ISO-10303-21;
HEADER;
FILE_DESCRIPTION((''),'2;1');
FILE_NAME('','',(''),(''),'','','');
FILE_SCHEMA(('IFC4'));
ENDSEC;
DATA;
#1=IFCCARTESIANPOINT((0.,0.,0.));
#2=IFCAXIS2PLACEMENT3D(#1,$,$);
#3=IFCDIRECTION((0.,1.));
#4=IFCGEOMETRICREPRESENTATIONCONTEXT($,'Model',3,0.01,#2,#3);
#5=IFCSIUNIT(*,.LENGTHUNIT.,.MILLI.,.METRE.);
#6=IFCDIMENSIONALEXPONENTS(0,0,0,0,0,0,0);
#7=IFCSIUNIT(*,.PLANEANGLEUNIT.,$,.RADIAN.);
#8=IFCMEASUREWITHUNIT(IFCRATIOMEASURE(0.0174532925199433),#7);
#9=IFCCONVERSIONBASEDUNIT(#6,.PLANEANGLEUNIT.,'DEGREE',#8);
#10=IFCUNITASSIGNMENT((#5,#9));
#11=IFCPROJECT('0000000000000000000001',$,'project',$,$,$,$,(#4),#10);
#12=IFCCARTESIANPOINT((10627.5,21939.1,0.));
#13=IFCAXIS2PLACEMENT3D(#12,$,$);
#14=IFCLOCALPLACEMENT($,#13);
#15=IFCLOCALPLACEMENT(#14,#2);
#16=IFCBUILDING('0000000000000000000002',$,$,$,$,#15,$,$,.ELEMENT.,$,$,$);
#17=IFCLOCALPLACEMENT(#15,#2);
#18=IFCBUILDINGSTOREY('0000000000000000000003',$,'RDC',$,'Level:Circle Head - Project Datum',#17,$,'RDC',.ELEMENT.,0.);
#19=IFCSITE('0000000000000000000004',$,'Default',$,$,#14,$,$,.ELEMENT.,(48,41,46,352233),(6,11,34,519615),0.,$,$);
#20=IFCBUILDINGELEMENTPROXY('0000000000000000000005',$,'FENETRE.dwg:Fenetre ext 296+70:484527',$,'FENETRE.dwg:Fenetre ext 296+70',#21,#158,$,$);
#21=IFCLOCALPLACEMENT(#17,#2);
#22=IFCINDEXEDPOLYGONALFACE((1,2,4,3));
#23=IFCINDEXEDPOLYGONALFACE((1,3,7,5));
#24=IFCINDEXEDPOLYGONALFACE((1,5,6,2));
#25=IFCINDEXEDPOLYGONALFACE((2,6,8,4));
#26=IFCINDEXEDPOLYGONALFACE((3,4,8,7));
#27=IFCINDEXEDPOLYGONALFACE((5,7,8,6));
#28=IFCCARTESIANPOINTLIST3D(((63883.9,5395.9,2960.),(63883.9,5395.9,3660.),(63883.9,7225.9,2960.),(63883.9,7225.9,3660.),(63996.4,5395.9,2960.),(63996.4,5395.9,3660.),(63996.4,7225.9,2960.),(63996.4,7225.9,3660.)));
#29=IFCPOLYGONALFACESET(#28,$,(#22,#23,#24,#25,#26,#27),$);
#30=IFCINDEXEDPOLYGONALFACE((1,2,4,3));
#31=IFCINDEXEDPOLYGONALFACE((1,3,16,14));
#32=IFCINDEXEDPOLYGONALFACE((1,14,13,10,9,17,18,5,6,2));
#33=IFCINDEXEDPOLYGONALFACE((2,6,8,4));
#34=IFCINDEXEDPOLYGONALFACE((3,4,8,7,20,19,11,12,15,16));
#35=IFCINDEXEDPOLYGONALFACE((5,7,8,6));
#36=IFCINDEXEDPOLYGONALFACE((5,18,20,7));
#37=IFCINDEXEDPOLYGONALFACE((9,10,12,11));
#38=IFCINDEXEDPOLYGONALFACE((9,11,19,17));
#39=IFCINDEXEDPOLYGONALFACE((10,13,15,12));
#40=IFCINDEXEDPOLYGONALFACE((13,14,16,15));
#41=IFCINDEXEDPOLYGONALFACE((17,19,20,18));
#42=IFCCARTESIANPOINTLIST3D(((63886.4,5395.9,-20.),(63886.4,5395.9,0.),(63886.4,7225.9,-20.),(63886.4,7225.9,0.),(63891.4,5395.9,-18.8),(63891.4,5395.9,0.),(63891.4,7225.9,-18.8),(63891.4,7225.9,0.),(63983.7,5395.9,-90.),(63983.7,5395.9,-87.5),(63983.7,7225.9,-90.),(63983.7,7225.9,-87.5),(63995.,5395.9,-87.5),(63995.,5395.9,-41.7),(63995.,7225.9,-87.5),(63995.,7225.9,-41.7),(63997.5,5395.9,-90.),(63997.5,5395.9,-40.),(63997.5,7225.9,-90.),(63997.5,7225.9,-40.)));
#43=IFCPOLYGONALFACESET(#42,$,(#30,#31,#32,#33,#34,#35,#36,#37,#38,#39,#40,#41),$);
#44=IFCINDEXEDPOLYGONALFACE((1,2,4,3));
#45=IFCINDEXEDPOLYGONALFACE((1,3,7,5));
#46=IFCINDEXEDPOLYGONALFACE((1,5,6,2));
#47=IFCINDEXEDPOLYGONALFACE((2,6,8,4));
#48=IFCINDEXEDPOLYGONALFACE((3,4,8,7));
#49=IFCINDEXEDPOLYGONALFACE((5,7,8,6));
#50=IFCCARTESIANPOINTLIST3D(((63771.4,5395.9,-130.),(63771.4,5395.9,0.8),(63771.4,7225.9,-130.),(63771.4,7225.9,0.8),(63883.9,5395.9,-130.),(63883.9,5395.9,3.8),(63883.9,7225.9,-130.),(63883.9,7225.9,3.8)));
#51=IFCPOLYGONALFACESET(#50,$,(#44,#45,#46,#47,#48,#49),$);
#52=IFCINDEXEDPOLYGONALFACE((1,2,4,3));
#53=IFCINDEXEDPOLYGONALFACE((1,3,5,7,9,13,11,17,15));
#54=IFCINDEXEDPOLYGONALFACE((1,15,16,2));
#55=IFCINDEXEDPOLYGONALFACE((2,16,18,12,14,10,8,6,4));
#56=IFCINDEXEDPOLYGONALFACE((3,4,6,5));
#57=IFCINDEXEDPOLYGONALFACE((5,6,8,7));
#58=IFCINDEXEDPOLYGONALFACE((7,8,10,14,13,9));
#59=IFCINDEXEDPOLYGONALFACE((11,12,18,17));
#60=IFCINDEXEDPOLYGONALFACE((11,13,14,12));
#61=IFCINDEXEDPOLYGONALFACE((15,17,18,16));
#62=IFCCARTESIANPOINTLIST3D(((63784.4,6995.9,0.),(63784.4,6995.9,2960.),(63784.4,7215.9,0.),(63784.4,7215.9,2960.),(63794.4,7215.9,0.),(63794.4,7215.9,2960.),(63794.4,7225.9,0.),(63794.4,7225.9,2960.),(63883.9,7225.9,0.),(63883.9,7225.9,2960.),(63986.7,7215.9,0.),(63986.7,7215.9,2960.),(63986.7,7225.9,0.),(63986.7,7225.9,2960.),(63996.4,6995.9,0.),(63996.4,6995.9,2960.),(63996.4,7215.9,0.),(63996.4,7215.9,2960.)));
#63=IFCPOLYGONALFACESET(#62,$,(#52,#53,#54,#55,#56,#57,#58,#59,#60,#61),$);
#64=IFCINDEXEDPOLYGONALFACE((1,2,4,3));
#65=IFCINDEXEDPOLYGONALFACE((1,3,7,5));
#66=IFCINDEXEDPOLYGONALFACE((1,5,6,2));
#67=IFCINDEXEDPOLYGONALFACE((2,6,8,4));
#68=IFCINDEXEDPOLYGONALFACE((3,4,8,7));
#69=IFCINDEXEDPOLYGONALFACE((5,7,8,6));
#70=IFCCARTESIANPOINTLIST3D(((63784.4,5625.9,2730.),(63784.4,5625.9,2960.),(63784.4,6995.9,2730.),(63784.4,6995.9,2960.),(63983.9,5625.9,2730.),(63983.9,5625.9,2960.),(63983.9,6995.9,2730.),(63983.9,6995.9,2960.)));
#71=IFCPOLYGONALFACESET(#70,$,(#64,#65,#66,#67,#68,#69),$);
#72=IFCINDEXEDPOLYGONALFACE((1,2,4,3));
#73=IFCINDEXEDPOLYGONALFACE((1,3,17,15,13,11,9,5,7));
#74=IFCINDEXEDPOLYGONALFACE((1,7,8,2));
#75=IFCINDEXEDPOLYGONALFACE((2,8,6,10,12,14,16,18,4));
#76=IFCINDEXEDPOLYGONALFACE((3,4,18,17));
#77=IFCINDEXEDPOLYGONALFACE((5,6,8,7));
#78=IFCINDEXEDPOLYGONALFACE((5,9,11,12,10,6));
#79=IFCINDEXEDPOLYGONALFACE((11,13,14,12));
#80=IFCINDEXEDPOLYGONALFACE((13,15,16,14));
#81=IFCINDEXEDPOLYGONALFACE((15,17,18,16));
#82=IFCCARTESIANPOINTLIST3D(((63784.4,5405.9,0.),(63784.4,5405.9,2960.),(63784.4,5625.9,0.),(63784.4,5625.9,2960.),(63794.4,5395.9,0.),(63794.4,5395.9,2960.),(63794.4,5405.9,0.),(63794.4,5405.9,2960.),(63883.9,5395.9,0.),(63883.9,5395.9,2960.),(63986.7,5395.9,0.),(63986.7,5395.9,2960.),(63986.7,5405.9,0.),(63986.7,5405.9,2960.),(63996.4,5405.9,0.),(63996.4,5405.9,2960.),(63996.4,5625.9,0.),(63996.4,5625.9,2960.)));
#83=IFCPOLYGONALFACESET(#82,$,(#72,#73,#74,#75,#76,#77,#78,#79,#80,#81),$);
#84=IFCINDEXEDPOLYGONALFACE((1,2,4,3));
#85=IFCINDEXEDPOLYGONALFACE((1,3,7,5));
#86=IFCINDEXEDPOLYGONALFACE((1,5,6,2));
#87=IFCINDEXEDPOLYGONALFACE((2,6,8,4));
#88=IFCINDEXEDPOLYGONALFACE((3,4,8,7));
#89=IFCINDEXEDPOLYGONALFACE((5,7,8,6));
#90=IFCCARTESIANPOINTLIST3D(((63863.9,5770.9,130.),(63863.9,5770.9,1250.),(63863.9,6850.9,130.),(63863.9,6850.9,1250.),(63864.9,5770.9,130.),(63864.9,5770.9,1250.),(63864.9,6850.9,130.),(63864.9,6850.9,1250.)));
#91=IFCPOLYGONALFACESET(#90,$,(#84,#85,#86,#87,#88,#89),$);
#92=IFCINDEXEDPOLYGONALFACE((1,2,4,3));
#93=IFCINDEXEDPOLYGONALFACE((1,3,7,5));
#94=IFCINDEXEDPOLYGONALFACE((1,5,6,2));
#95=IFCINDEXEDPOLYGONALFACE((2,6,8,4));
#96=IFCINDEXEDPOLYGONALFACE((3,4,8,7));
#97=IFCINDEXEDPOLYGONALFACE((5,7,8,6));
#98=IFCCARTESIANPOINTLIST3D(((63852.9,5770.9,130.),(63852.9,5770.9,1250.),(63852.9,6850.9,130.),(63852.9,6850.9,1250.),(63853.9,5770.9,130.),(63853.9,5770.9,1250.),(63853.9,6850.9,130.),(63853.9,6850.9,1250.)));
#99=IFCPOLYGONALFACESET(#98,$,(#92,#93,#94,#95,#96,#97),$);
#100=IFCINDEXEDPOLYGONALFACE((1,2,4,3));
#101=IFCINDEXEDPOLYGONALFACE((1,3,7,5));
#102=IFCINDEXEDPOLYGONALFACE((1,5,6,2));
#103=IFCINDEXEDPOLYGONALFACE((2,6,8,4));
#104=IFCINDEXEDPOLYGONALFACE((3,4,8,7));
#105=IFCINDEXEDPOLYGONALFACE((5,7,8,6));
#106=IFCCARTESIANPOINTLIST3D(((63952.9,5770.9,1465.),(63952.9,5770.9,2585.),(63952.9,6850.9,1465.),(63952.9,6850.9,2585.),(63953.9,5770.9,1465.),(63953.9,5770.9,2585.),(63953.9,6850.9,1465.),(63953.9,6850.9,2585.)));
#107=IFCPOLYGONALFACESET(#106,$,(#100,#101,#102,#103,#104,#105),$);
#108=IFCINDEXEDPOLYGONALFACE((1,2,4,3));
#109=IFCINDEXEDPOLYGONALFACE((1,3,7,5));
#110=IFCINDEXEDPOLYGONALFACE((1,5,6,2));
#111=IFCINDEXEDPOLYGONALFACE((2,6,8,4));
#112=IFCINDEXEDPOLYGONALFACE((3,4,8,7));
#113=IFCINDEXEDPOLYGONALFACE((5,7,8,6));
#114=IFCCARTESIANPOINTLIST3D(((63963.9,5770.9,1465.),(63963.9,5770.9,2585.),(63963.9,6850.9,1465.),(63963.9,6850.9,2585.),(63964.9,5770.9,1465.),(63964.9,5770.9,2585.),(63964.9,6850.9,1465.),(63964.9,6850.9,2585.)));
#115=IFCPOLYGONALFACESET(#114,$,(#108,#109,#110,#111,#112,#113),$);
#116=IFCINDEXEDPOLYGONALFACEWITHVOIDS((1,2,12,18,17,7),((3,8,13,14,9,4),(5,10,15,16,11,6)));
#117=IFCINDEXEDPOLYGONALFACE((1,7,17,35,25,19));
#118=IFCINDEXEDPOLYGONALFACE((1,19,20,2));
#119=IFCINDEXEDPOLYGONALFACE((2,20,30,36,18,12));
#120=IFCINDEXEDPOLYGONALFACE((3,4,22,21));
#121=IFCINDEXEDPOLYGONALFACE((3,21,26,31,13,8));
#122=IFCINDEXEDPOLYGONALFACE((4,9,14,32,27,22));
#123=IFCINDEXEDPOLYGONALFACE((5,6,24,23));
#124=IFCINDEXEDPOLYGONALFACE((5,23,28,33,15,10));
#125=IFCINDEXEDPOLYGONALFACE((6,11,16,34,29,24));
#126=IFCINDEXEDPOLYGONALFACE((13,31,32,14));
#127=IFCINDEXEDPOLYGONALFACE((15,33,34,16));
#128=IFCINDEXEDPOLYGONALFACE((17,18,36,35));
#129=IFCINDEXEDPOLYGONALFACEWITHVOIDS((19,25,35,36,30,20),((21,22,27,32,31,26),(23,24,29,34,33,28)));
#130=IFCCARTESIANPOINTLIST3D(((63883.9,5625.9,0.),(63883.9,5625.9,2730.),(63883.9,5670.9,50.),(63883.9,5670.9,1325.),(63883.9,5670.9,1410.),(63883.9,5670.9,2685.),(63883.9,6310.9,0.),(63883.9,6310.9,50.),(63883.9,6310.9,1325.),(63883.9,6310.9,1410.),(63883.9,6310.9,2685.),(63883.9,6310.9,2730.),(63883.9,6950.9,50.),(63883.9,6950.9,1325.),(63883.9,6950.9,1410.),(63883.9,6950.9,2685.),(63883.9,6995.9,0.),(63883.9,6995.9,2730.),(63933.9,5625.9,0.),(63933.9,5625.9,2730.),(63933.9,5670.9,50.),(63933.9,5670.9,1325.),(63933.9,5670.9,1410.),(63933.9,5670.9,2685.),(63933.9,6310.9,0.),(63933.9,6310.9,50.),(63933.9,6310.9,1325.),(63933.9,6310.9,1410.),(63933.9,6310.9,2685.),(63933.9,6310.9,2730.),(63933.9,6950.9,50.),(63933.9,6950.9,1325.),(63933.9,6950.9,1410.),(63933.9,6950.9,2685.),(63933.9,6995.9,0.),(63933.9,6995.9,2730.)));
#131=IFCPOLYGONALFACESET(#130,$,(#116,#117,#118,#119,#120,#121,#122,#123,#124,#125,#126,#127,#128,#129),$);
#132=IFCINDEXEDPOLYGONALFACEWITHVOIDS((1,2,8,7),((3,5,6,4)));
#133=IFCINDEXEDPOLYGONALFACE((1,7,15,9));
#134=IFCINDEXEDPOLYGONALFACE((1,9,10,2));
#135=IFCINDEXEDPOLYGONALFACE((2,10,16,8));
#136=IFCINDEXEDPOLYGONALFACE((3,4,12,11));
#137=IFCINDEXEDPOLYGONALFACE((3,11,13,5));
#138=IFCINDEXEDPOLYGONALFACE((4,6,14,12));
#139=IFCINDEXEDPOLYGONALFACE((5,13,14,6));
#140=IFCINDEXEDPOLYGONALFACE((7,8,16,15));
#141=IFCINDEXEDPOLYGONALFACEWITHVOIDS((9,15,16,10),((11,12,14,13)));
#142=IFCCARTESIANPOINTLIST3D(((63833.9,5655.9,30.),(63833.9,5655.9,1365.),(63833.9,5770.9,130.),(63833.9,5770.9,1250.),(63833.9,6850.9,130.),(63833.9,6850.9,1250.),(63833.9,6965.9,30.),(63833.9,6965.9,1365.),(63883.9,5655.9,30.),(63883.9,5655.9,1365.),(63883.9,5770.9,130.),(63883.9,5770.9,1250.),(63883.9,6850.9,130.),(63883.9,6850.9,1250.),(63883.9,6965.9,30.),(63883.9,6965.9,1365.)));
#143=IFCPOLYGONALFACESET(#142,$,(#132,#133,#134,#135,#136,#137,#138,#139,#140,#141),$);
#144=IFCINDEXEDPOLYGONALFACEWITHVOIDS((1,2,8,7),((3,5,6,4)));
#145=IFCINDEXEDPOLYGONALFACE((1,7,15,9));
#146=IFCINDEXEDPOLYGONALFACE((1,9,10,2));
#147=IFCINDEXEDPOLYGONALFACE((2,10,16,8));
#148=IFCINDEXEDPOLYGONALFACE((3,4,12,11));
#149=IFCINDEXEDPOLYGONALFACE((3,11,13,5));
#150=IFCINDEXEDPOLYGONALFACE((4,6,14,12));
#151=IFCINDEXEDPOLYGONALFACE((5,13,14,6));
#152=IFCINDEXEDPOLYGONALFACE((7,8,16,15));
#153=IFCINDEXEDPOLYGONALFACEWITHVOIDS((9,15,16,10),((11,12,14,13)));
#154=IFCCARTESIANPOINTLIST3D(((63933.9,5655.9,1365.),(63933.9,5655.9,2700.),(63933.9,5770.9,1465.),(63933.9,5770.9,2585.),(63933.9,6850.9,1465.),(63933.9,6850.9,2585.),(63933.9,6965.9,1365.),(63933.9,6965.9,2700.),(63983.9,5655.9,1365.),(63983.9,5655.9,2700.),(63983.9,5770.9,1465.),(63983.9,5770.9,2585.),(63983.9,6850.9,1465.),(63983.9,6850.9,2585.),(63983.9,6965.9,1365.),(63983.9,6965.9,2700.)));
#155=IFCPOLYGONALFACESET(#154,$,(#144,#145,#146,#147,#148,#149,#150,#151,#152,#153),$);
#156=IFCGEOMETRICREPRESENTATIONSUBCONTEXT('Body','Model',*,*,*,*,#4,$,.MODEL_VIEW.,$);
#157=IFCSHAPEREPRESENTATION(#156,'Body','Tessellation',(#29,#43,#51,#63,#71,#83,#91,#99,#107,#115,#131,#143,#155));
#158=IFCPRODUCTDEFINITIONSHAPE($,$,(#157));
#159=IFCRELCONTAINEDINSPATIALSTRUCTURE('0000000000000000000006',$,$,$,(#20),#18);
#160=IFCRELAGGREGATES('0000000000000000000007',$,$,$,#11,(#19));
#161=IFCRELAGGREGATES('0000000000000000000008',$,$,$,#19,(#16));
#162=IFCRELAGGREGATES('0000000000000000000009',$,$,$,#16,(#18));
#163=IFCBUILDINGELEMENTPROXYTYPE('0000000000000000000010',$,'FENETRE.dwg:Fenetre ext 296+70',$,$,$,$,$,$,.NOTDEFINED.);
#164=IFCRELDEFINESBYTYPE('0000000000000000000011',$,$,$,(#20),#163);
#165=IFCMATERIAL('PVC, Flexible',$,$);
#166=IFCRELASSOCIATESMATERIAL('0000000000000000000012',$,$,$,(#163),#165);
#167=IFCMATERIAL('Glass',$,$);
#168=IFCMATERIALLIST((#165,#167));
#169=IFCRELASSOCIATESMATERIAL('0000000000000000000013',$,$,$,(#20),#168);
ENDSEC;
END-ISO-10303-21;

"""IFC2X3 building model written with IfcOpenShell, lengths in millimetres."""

from ifc_helpers import new_model, entity, si_unit, converted_unit, direction, frame, frame_2d, origin, origin_2d_with_axis, place, context, subcontext, project, spatial, polyline, rectangle, outline, extrude, source, transform, mapped, material, material_list, type_object, type_shapes, element, save


model = new_model("IFC2X3")

# Units and contexts
model_context = context("Model", 3, precision=0.01, world=origin(), true_north=direction((0.0, 1.0)))
body_context = subcontext(model_context, "Body", "Model", "MODEL_VIEW")
ifc_project = project(units=[si_unit("LENGTHUNIT", "METRE", prefix="MILLI"), converted_unit("PLANEANGLEUNIT", "DEGREE", entity("IfcRatioMeasure", 0.0174532925199433), si_unit("PLANEANGLEUNIT", "RADIAN"), dimensions=[0, 0, 0, 0, 0, 0, 0])], contexts=[model_context])

# Site, building, storey
site_placement = place(None, frame((10627.5, 21939.1, 0.0)))
site = spatial("IfcSite", under=ifc_project, at=site_placement, Name="Default", CompositionType="ELEMENT", RefLatitude=(48, 41, 46, 352233), RefLongitude=(6, 11, 34, 519615), RefElevation=0.0)
building_placement = place(site_placement, origin())
building = spatial("IfcBuilding", under=site, at=building_placement, CompositionType="ELEMENT")
storey_placement = place(building_placement, origin())
storey = spatial("IfcBuildingStorey", under=building, at=storey_placement, Name="RDC", ObjectType="Level:Circle Head - Project Datum", LongName="RDC", CompositionType="ELEMENT", Elevation=0.0)

# Building element proxy
ifc_material_1 = material(Name="PVC, Flexible")
ifc_material_2 = material(Name="Glass")
building_element_proxy_type_1 = type_object("IfcBuildingElementProxyType", Name="FENETRE.dwg:Fenetre ext 296+70", PredefinedType="NOTDEFINED", material=ifc_material_1)
shared_shape_1 = source(origin(), body_context, "Body", "SweptSolid", [
    extrude(rectangle(XDim=112.5, YDim=1830.0, at=origin_2d_with_axis()), frame((-10.4, -56.3, 2960.0), z_axis=(0.0, 0.0, 1.0), x_axis=(0.0, 1.0, 0.0)), (0.0, 0.0, 1.0), 700.0),
    extrude(outline(polyline([(27.5, -64.4), (47.5, -64.4), (47.5, -59.4), (28.8, -59.4), (7.5, 46.7), (-42.5, 46.7), (-42.5, 32.9), (-40.0, 32.9), (-40.0, 44.2), (5.8, 44.2), (27.5, -64.4)])), frame((-925.4, -66.9, -47.5), z_axis=(1.0, 0.0, 0.0), x_axis=(0.0, 0.0, 1.0)), (0.0, 0.0, 1.0), 1830.0),
    extrude(outline(polyline([(-54.5, -66.1), (58.0, -66.1), (54.5, 67.6), (-58.0, 64.6), (-54.5, -66.1)])), frame((-925.4, 56.3, -63.8), z_axis=(1.0, 0.0, 0.0), x_axis=(0.0, -0.999645, 0.02665)), (0.0, 0.0, 1.0), 1830.0),
    extrude(outline(polyline([(-97.0, -55.6), (5.9, -55.6), (95.4, -55.6), (95.4, -45.6), (105.4, -45.6), (105.4, 174.4), (-106.6, 174.4), (-106.6, -45.6), (-97.0, -45.6), (-97.0, -55.6)])), frame((849.0, -5.9, 0.0), z_axis=(0.0, 0.0, 1.0), x_axis=(0.0, 1.0, 0.0)), (0.0, 0.0, 1.0), 2960.0),
    extrude(rectangle(XDim=1370.0, YDim=199.5, at=origin_2d_with_axis()), frame((-10.4, -0.3, 2730.0), z_axis=(0.0, 0.0, 1.0), x_axis=(-1.0, 0.0, 0.0)), (0.0, 0.0, 1.0), 230.0),
    extrude(outline(polyline([(-55.6, 97.0), (-55.6, -5.9), (-55.6, -95.4), (-45.6, -95.4), (-45.6, -105.4), (174.4, -105.4), (174.4, 106.6), (-45.6, 106.6), (-45.6, 97.0), (-55.6, 97.0)])), frame((-869.9, -5.9, 0.0), z_axis=(0.0, 0.0, -1.0), x_axis=(1.0, 0.0, 0.0)), (0.0, 0.0, -1.0), 2960.0),
    extrude(rectangle(XDim=1080.0, YDim=1.0, at=origin_2d_with_axis()), frame((-10.4, 19.5, 130.0), z_axis=(0.0, 0.0, 1.0), x_axis=(-1.0, 0.0, 0.0)), (0.0, 0.0, 1.0), 1120.0),
    extrude(rectangle(XDim=1080.0, YDim=1.0, at=origin_2d_with_axis()), frame((-10.4, 30.5, 130.0), z_axis=(0.0, 0.0, 1.0), x_axis=(-1.0, 0.0, 0.0)), (0.0, 0.0, 1.0), 1120.0),
    extrude(rectangle(XDim=1080.0, YDim=1.0, at=frame_2d((0.0, 0.0), x_axis=(1.0, 0.0))), frame((-10.4, -69.5, 1465.0), z_axis=(0.0, 0.0, 1.0), x_axis=(-1.0, 0.0, 0.0)), (0.0, 0.0, 1.0), 1120.0),
    extrude(rectangle(XDim=1080.0, YDim=1.0, at=frame_2d((0.0, 0.0), x_axis=(1.0, 0.0))), frame((-10.4, -80.5, 1465.0), z_axis=(0.0, 0.0, 1.0), x_axis=(-1.0, 0.0, 0.0)), (0.0, 0.0, 1.0), 1120.0),
    extrude(outline(polyline([(-685.0, -1365.0), (0.0, -1365.0), (685.0, -1365.0), (685.0, 1365.0), (0.0, 1365.0), (-685.0, 1365.0), (-685.0, -1365.0)]), holes=[polyline([(-640.0, -1320.0), (-640.0, -45.0), (0.0, -45.0), (640.0, -45.0), (640.0, -1320.0), (0.0, -1320.0), (-640.0, -1320.0)]), polyline([(-640.0, 40.0), (-640.0, 1315.0), (0.0, 1315.0), (640.0, 1315.0), (640.0, 40.0), (0.0, 40.0), (-640.0, 40.0)])]), frame((-10.4, -50.0, 1365.0), z_axis=(0.0, 1.0, 0.0), x_axis=(1.0, 0.0, 0.0)), (0.0, 0.0, 1.0), 50.0),
    extrude(outline(polyline([(-655.0, -667.5), (655.0, -667.5), (655.0, 667.5), (-655.0, 667.5), (-655.0, -667.5)]), holes=[polyline([(-540.0, 552.5), (540.0, 552.5), (540.0, -567.5), (-540.0, -567.5), (-540.0, 552.5)])]), frame((-10.4, 0.0, 697.5), z_axis=(0.0, 1.0, 0.0), x_axis=(-1.0, 0.0, 0.0)), (0.0, 0.0, 1.0), 50.0),
    extrude(outline(polyline([(-655.0, -667.5), (655.0, -667.5), (655.0, 667.5), (-655.0, 667.5), (-655.0, -667.5)]), holes=[polyline([(-540.0, 552.5), (540.0, 552.5), (540.0, -567.5), (-540.0, -567.5), (-540.0, 552.5)])]), frame((-10.4, -100.0, 2032.5), z_axis=(0.0, 1.0, 0.0), x_axis=(-1.0, 0.0, 0.0)), (0.0, 0.0, 1.0), 50.0),
])
type_shapes(building_element_proxy_type_1, [shared_shape_1])
ifc_material_list_1 = material_list([ifc_material_1, ifc_material_2])
proxy_1_placement = place(storey_placement, frame((63883.9, 6321.3, 0.0), z_axis=(0.0, 0.0, 1.0), x_axis=(0.0, 1.0, 0.0)))
element("IfcBuildingElementProxy", 1, at=proxy_1_placement, inside=storey, type_object=building_element_proxy_type_1, material=ifc_material_list_1, Name="FENETRE.dwg:Fenetre ext 296+70:484527", ObjectType="FENETRE.dwg:Fenetre ext 296+70", context=body_context, shape_type="MappedRepresentation", body=[
    mapped(shared_shape_1, transform((0.0, 0.0, 0.0), scale=1.0)),
])

save(model, "model.ifc")
